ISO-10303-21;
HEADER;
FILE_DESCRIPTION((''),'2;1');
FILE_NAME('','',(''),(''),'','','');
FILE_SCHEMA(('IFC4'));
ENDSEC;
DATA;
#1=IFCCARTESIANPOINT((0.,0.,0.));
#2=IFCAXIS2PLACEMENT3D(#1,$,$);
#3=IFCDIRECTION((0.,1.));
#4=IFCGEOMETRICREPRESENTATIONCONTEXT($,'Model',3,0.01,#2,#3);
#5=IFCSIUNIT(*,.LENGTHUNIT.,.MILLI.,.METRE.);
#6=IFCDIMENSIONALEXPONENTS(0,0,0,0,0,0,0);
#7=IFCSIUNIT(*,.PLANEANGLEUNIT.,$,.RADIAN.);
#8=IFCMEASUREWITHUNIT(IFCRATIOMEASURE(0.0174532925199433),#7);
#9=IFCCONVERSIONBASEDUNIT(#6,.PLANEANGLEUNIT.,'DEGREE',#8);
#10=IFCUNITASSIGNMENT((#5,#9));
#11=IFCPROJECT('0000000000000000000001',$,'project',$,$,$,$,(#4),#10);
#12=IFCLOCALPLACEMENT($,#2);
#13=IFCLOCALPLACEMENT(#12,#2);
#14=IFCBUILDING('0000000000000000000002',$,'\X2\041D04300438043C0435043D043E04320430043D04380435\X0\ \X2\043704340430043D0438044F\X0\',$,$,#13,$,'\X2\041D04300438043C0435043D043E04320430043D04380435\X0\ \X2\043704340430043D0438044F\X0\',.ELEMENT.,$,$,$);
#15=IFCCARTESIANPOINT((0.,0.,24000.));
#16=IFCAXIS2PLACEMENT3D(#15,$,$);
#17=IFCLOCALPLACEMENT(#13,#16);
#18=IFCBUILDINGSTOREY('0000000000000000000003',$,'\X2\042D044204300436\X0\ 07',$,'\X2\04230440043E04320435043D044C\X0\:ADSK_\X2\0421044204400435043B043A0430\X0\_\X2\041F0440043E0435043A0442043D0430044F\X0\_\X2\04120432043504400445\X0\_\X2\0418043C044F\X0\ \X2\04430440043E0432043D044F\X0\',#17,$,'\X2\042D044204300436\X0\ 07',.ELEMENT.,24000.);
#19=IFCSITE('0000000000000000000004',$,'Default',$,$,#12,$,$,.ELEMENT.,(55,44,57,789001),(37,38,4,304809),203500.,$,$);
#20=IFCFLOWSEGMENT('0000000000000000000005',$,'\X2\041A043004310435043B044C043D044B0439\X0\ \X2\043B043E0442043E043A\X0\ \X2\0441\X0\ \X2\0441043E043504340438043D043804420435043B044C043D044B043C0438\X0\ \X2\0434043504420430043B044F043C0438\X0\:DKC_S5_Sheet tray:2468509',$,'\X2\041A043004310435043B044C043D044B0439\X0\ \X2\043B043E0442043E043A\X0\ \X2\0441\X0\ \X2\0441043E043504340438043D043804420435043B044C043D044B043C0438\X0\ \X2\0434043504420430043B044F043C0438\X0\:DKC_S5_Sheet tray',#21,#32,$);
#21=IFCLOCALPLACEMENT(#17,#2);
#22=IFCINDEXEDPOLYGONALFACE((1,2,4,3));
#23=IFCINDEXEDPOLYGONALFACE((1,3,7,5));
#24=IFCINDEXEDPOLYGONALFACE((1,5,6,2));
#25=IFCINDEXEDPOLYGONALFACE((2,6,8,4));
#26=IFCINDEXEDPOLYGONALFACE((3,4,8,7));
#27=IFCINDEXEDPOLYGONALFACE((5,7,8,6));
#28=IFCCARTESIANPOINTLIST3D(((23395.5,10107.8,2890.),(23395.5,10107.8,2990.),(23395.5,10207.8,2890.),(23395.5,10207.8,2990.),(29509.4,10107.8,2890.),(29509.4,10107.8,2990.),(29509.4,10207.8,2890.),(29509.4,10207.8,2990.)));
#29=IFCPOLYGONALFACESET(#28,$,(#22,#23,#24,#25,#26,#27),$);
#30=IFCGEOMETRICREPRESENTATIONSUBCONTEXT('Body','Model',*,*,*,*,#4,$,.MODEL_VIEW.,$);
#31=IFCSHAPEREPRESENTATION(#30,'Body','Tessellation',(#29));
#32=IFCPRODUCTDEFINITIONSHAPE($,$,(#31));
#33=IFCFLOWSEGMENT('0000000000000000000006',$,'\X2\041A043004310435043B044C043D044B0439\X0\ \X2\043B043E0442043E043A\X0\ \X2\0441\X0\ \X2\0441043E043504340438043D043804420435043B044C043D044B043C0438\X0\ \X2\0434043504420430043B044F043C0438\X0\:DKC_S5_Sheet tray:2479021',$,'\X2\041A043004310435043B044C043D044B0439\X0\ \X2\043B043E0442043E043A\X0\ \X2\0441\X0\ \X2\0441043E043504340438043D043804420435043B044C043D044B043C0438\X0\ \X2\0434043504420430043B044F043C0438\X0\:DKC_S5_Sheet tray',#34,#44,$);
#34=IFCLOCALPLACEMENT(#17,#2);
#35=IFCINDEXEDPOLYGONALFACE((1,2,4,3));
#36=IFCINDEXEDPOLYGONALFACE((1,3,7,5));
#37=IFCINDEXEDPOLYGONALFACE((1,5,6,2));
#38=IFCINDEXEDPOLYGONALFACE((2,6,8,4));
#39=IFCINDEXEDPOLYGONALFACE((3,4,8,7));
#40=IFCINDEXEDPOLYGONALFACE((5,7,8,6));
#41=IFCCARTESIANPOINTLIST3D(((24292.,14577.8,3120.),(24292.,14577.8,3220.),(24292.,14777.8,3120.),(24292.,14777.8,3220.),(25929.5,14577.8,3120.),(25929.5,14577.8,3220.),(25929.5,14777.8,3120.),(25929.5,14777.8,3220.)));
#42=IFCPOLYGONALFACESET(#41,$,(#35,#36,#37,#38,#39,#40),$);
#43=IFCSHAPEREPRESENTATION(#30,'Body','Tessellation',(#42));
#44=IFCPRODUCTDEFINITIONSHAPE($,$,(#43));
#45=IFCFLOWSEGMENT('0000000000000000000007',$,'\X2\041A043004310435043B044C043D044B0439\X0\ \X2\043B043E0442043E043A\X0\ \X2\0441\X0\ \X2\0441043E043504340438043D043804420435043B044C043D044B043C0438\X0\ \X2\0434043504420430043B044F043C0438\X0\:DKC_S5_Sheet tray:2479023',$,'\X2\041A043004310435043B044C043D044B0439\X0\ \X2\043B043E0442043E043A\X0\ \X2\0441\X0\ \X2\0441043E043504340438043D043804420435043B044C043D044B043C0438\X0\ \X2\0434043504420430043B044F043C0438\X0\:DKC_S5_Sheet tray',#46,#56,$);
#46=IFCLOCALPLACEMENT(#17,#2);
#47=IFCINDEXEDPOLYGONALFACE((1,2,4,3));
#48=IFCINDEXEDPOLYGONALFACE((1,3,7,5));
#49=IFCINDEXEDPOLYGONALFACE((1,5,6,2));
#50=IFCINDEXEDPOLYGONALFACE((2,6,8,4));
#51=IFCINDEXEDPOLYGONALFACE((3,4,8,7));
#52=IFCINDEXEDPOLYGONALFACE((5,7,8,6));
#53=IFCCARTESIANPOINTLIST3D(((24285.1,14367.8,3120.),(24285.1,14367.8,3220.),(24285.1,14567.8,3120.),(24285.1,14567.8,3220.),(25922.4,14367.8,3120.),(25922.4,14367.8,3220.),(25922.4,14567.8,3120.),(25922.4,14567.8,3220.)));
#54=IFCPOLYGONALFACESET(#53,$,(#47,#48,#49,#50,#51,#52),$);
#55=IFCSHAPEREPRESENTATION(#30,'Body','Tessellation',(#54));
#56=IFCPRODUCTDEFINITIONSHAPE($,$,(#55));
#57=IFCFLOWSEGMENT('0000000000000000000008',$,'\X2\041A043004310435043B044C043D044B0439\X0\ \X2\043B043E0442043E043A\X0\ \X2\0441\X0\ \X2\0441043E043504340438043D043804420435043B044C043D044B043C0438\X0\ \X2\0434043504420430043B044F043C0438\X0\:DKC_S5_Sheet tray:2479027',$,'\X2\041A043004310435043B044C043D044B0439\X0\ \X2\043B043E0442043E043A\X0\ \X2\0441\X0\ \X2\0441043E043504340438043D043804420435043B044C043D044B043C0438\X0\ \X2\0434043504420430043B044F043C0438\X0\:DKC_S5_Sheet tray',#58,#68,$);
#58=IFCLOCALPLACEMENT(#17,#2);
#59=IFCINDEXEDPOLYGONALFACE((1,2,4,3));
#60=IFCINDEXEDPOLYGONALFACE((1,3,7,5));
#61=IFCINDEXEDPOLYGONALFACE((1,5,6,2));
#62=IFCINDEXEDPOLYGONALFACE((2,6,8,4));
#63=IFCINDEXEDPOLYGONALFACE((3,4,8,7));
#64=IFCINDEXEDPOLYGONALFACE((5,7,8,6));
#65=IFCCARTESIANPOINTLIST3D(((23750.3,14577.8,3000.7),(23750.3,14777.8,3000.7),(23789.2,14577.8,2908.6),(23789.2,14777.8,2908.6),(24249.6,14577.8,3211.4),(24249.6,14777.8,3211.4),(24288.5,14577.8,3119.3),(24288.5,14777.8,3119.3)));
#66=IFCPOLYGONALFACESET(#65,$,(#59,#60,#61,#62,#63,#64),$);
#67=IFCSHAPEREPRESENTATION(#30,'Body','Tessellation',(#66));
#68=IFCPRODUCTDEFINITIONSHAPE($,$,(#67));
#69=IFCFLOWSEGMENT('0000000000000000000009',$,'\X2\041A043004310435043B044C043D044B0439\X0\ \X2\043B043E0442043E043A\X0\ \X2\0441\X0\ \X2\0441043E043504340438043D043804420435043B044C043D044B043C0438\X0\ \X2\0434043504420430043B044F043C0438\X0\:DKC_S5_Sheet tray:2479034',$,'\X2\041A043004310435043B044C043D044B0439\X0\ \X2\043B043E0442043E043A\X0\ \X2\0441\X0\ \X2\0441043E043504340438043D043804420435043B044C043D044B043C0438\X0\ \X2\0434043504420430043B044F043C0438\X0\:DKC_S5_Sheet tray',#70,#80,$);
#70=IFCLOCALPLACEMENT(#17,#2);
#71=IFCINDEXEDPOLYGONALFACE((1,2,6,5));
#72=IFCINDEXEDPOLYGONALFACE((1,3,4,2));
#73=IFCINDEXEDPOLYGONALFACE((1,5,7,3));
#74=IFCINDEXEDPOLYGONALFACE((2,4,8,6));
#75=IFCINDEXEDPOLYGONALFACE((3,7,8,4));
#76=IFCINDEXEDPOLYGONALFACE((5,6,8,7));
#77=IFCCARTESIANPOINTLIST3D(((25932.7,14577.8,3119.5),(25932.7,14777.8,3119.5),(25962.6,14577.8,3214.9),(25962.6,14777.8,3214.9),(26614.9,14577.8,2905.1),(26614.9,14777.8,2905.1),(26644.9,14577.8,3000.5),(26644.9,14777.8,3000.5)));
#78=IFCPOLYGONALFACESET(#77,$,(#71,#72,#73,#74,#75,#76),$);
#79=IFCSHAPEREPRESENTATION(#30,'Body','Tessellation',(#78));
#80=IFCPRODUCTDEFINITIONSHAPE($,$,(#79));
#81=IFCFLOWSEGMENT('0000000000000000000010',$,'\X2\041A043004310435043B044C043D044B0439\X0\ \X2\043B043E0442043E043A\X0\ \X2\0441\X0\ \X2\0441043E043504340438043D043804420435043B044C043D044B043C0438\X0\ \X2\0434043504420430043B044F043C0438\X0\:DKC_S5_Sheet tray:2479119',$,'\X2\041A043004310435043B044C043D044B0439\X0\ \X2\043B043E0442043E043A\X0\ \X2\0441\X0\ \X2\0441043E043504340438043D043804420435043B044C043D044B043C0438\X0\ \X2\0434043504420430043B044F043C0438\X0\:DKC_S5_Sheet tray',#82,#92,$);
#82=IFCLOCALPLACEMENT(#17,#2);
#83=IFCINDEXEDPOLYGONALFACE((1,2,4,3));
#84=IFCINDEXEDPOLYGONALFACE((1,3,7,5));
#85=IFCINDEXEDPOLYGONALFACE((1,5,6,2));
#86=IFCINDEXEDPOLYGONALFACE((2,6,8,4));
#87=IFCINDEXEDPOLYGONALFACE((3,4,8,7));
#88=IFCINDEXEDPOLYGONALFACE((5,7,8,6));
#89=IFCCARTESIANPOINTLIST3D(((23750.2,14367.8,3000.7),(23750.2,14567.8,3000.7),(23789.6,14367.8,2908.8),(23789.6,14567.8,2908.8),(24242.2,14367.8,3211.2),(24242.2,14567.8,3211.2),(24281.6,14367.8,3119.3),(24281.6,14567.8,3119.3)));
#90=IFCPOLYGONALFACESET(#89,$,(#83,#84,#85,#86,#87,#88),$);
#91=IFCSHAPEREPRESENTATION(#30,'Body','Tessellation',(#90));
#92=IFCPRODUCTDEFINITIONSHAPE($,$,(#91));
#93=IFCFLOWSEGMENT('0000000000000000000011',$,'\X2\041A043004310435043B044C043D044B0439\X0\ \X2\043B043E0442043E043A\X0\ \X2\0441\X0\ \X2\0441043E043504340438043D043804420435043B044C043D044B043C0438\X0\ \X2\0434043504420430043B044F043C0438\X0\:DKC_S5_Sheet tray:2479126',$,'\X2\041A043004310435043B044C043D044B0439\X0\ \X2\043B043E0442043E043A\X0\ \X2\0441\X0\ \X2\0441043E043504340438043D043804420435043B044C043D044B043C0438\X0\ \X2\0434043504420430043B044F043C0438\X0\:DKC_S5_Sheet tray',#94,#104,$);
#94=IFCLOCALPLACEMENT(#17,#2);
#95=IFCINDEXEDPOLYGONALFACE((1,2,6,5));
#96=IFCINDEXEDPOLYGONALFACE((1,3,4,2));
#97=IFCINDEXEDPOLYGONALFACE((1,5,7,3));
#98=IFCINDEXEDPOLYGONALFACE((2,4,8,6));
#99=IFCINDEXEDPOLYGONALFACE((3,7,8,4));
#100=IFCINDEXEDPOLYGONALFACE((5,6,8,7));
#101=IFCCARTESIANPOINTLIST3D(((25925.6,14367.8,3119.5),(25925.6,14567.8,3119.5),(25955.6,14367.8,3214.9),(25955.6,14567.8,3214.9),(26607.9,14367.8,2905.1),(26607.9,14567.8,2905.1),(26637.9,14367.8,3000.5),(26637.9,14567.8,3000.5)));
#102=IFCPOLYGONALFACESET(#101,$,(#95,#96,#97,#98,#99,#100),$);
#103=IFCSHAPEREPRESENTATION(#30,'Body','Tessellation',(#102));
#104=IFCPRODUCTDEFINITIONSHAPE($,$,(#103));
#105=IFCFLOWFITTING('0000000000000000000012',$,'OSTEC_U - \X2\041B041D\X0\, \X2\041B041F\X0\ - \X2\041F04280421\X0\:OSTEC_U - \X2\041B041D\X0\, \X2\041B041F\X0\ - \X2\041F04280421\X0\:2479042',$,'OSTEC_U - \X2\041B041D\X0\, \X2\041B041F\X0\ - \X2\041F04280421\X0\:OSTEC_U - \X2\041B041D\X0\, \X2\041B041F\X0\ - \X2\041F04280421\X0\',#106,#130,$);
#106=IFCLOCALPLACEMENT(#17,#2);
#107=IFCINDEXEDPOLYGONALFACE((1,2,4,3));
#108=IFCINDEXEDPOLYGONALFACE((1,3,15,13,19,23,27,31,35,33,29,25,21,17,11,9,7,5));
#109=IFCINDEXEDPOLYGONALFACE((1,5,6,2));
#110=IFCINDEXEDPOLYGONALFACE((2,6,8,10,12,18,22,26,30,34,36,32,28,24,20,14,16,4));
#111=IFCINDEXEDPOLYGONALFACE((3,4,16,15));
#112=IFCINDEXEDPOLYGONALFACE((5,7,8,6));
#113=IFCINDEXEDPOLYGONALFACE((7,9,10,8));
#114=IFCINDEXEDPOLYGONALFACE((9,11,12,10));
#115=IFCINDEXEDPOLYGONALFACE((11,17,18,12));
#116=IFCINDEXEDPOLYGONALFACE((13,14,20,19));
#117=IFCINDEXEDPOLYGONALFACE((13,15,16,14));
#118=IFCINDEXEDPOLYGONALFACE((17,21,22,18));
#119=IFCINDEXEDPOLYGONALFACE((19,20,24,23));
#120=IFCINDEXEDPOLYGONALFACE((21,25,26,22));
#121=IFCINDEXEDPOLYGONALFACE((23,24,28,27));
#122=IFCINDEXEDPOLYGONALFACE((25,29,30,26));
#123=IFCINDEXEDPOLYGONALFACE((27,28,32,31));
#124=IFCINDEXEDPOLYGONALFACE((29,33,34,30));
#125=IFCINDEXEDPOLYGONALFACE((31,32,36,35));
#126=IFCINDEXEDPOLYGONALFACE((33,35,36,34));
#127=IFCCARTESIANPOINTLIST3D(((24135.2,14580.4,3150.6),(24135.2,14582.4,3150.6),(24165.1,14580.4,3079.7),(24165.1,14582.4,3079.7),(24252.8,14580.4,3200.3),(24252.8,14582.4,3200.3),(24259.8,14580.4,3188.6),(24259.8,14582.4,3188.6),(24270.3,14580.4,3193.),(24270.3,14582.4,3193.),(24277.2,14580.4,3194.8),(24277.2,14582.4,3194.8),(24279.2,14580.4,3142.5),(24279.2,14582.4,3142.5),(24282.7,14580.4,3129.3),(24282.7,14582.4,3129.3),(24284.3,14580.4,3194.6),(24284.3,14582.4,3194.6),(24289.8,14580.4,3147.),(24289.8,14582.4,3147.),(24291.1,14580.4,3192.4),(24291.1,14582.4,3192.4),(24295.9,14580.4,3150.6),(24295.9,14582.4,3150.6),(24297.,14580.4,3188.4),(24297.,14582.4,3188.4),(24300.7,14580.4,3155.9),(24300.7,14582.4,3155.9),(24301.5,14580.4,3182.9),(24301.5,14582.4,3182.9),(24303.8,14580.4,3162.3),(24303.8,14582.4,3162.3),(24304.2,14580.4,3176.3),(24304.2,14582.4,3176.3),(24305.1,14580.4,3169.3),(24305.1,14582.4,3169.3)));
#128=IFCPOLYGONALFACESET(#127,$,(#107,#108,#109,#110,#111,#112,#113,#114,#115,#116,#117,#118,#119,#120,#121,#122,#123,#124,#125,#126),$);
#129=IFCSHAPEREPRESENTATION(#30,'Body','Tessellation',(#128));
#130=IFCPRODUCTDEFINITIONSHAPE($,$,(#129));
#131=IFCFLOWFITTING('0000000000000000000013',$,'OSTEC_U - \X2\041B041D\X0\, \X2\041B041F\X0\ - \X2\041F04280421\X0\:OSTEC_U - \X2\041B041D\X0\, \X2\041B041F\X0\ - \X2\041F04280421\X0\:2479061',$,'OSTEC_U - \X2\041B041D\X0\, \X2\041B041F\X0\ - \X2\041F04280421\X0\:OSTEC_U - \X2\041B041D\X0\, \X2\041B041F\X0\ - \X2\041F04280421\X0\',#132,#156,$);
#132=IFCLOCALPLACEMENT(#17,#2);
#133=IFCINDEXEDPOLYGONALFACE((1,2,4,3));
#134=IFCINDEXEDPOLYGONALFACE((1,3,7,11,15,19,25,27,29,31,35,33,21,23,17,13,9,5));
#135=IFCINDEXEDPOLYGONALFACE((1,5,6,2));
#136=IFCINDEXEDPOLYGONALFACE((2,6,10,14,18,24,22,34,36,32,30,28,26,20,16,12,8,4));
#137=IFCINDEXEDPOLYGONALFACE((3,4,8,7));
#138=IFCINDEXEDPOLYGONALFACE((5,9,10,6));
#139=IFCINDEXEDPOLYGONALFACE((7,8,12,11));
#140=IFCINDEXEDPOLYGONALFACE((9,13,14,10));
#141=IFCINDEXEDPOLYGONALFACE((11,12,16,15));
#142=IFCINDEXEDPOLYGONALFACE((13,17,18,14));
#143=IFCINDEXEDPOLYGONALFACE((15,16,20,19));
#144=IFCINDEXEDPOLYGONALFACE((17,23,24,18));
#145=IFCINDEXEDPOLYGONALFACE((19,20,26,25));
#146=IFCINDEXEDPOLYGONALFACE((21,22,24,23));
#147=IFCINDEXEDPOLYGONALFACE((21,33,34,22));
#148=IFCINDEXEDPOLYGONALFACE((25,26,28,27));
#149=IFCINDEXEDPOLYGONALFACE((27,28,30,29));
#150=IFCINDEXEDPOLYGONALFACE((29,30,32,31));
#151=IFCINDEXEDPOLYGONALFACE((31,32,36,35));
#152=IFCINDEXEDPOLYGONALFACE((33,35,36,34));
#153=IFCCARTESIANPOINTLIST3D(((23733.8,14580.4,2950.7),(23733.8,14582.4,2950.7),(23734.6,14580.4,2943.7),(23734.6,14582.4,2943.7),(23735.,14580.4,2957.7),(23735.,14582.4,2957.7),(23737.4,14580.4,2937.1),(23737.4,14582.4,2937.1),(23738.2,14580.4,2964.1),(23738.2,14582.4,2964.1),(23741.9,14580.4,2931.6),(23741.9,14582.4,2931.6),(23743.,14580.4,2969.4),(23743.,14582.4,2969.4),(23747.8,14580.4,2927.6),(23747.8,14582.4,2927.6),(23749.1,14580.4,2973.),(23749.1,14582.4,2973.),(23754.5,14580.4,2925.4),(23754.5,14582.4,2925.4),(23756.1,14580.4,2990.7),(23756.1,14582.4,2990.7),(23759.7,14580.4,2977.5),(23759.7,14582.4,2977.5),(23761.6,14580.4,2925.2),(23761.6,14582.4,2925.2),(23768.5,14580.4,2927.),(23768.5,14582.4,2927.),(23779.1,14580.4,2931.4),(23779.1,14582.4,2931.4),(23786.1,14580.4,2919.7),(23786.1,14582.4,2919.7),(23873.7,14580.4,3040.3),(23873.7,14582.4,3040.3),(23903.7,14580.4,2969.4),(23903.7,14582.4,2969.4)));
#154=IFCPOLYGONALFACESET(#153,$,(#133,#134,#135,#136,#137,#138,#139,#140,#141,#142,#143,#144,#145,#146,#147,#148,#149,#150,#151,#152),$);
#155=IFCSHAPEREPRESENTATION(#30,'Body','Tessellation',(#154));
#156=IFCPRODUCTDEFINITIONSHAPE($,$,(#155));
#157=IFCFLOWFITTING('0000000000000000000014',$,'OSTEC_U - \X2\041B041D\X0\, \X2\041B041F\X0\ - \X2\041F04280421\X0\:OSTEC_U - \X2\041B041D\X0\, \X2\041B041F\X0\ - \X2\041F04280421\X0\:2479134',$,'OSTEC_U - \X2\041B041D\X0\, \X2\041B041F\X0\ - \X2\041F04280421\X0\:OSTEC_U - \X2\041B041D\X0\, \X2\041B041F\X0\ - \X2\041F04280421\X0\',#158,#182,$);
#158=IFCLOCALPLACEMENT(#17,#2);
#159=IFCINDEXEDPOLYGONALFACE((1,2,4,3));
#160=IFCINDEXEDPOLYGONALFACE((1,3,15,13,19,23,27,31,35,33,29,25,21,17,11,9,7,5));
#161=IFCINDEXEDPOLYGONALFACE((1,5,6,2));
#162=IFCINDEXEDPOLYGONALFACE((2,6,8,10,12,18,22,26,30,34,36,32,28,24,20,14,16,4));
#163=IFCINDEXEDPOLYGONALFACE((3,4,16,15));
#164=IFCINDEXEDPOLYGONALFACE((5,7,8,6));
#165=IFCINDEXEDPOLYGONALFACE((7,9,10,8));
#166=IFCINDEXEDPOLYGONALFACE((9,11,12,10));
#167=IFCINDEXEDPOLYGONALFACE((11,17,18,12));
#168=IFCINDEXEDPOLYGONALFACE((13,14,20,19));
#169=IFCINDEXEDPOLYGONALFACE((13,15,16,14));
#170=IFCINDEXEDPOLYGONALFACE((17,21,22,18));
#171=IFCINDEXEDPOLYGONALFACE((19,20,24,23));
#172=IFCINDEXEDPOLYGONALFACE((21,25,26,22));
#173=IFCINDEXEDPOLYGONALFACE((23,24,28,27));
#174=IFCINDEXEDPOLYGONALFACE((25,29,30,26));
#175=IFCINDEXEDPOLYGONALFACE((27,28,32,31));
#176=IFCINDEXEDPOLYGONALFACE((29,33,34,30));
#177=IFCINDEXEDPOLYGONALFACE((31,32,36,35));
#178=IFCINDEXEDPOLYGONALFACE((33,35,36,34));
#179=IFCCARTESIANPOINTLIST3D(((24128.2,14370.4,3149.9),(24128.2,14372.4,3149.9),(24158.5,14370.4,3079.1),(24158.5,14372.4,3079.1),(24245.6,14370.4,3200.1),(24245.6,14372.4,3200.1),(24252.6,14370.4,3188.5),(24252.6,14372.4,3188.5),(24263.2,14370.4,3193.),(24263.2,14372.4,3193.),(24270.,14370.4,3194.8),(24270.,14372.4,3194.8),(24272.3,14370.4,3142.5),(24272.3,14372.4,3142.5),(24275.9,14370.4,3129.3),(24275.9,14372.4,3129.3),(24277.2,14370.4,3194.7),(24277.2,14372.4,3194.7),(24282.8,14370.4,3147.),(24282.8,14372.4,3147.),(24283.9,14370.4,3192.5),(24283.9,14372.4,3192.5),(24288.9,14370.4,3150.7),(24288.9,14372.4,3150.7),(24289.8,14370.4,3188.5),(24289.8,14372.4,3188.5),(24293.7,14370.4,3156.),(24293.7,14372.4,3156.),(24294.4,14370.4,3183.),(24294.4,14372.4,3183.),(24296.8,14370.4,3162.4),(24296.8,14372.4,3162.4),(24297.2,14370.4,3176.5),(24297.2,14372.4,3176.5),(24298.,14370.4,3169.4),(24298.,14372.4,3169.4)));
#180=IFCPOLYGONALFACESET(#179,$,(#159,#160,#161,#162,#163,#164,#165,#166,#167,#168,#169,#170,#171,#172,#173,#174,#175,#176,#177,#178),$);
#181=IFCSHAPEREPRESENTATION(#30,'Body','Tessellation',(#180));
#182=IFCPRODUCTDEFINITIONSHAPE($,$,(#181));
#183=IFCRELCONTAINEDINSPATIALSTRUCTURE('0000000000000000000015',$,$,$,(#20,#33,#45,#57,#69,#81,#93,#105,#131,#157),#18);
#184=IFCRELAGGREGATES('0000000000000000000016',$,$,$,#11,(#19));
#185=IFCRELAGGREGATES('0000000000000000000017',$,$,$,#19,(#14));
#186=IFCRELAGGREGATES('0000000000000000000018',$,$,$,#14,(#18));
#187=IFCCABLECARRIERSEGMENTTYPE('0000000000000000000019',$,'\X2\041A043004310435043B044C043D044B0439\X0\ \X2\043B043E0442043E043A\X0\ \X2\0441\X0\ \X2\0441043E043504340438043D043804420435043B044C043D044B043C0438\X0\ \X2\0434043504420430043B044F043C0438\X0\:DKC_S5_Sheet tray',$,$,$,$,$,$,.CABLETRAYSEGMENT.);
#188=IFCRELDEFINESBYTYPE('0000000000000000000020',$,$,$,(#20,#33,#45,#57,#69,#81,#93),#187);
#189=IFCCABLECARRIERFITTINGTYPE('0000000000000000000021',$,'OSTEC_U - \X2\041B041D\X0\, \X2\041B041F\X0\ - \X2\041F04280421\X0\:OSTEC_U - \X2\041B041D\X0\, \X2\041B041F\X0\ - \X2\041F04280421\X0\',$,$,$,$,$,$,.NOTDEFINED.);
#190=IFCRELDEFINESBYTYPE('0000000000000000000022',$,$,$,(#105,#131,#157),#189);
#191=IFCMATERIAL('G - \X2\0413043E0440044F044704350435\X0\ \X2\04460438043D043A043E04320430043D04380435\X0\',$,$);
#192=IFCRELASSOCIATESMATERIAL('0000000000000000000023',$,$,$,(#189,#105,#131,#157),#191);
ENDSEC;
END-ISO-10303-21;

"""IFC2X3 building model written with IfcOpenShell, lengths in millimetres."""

from ifc_helpers import new_model, entity, si_unit, converted_unit, direction, frame, frame_2d, origin, origin_2d_with_axis, place, context, subcontext, project, spatial, polyline, circle_curve, parameter, trimmed, segment, composite_curve, rectangle, outline, extrude, source, transform, mapped, material, type_object, type_shapes, element, save


model = new_model("IFC2X3")

# Units and contexts
model_context = context("Model", 3, precision=0.01, world=origin(), true_north=direction((0.0, 1.0)))
body_context = subcontext(model_context, "Body", "Model", "MODEL_VIEW")
ifc_project = project(units=[si_unit("LENGTHUNIT", "METRE", prefix="MILLI"), converted_unit("PLANEANGLEUNIT", "DEGREE", entity("IfcRatioMeasure", 0.0174532925199433), si_unit("PLANEANGLEUNIT", "RADIAN"), dimensions=[0, 0, 0, 0, 0, 0, 0])], contexts=[model_context])

# Site, building, storey
site_placement = place(None, frame((0.0, 0.0, 0.0)))
site = spatial("IfcSite", under=ifc_project, at=site_placement, Name="Default", CompositionType="ELEMENT", RefLatitude=(55, 44, 57, 789001), RefLongitude=(37, 38, 4, 304809), RefElevation=203500.0)
building_placement = place(site_placement, origin())
building = spatial("IfcBuilding", under=site, at=building_placement, Name="Наименование здания", LongName="Наименование здания", CompositionType="ELEMENT")
storey_placement = place(building_placement, frame((0.0, 0.0, 24000.0)))
storey = spatial("IfcBuildingStorey", under=building, at=storey_placement, Name="Этаж 07", ObjectType="Уровень:ADSK_Стрелка_Проектная_Вверх_Имя уровня", LongName="Этаж 07", CompositionType="ELEMENT", Elevation=24000.0)

# Flow segments
cable_carrier_segment_type = type_object("IfcCableCarrierSegmentType", Name="Кабельный лоток с соединительными деталями:DKC_S5_Sheet tray", PredefinedType="CABLETRAYSEGMENT")
flow_segment_1_placement = place(storey_placement, frame((23395.5, 10107.8, 2890.0)))
element("IfcFlowSegment", 1, at=flow_segment_1_placement, inside=storey, type_object=cable_carrier_segment_type, Name="Кабельный лоток с соединительными деталями:DKC_S5_Sheet tray:2468509", ObjectType="Кабельный лоток с соединительными деталями:DKC_S5_Sheet tray", context=body_context, shape_type="SweptSolid", body=[
    extrude(rectangle(XDim=6114.0, YDim=100.0, at=frame_2d((0.0, 0.0), x_axis=(1.0, 0.0))), frame((3057.0, 50.0, 0.0), z_axis=(0.0, 0.0, 1.0), x_axis=(-1.0, 0.0, 0.0)), (0.0, 0.0, 1.0), 100.0),
])
flow_segment_2_placement = place(storey_placement, frame((24292.0, 14577.8, 3120.0)))
element("IfcFlowSegment", 2, at=flow_segment_2_placement, inside=storey, type_object=cable_carrier_segment_type, Name="Кабельный лоток с соединительными деталями:DKC_S5_Sheet tray:2479021", ObjectType="Кабельный лоток с соединительными деталями:DKC_S5_Sheet tray", context=body_context, shape_type="SweptSolid", body=[
    extrude(rectangle(XDim=1637.5, YDim=200.0, at=frame_2d((0.0, 0.0), x_axis=(1.0, 0.0))), frame((818.8, 100.0, 0.0), z_axis=(0.0, 0.0, 1.0), x_axis=(-1.0, 0.0, 0.0)), (0.0, 0.0, 1.0), 100.0),
])
flow_segment_3_placement = place(storey_placement, frame((24285.1, 14367.8, 3120.0)))
element("IfcFlowSegment", 3, at=flow_segment_3_placement, inside=storey, type_object=cable_carrier_segment_type, Name="Кабельный лоток с соединительными деталями:DKC_S5_Sheet tray:2479023", ObjectType="Кабельный лоток с соединительными деталями:DKC_S5_Sheet tray", context=body_context, shape_type="SweptSolid", body=[
    extrude(rectangle(XDim=1637.4, YDim=200.0, at=origin_2d_with_axis()), frame((818.7, 100.0, 0.0)), (0.0, 0.0, 1.0), 100.0),
])
flow_segment_4_placement = place(storey_placement, frame((23750.3, 14577.8, 2908.6)))
element("IfcFlowSegment", 4, at=flow_segment_4_placement, inside=storey, type_object=cable_carrier_segment_type, Name="Кабельный лоток с соединительными деталями:DKC_S5_Sheet tray:2479027", ObjectType="Кабельный лоток с соединительными деталями:DKC_S5_Sheet tray", context=body_context, shape_type="SweptSolid", body=[
    extrude(rectangle(XDim=100.0, YDim=200.0, at=frame_2d((0.0, 0.0), x_axis=(1.0, 0.0))), frame((19.4, 100.0, 46.1), z_axis=(0.921308, 0.0, 0.388834), x_axis=(-0.388834, 0.0, 0.921308)), (0.0, 0.0, 1.0), 541.9),
])
flow_segment_5_placement = place(storey_placement, frame((25932.7, 14577.8, 2905.1)))
element("IfcFlowSegment", 5, at=flow_segment_5_placement, inside=storey, type_object=cable_carrier_segment_type, Name="Кабельный лоток с соединительными деталями:DKC_S5_Sheet tray:2479034", ObjectType="Кабельный лоток с соединительными деталями:DKC_S5_Sheet tray", context=body_context, shape_type="SweptSolid", body=[
    extrude(rectangle(XDim=100.0, YDim=200.0, at=frame_2d((0.0, 0.0), x_axis=(1.0, 0.0))), frame((15.0, 100.0, 262.1), z_axis=(0.953994, 0.0, -0.299827), x_axis=(0.299827, 0.0, 0.953994)), (0.0, 0.0, 1.0), 715.2),
])
flow_segment_6_placement = place(storey_placement, frame((23750.2, 14367.8, 2908.8)))
element("IfcFlowSegment", 6, at=flow_segment_6_placement, inside=storey, type_object=cable_carrier_segment_type, Name="Кабельный лоток с соединительными деталями:DKC_S5_Sheet tray:2479119", ObjectType="Кабельный лоток с соединительными деталями:DKC_S5_Sheet tray", context=body_context, shape_type="SweptSolid", body=[
    extrude(rectangle(XDim=100.0, YDim=200.0, at=frame_2d((0.0, 0.0), x_axis=(1.0, 0.0))), frame((19.7, 100.0, 46.0), z_axis=(0.919387, 0.0, 0.393354), x_axis=(-0.393354, 0.0, 0.919387)), (0.0, 0.0, 1.0), 535.2),
])
flow_segment_7_placement = place(storey_placement, frame((25925.6, 14367.8, 2905.1)))
element("IfcFlowSegment", 7, at=flow_segment_7_placement, inside=storey, type_object=cable_carrier_segment_type, Name="Кабельный лоток с соединительными деталями:DKC_S5_Sheet tray:2479126", ObjectType="Кабельный лоток с соединительными деталями:DKC_S5_Sheet tray", context=body_context, shape_type="SweptSolid", body=[
    extrude(rectangle(XDim=100.0, YDim=200.0, at=frame_2d((0.0, 0.0), x_axis=(1.0, 0.0))), frame((15.0, 100.0, 262.1), z_axis=(0.953994, 0.0, -0.299827), x_axis=(0.299827, 0.0, 0.953994)), (0.0, 0.0, 1.0), 715.2),
])

# Flow fittings
ifc_material_1 = material(Name="G - Горячее цинкование")
cable_carrier_fitting_type_1 = type_object("IfcCableCarrierFittingType", Name="OSTEC_U - ЛН, ЛП - ПШС:OSTEC_U - ЛН, ЛП - ПШС", PredefinedType="NOTDEFINED", material=ifc_material_1)
shared_shape_1 = source(origin(), body_context, "Body", "SweptSolid", [
    extrude(outline(composite_curve([segment(trimmed(circle_curve(frame_2d((-41.5, 0.0), x_axis=(1.0, 0.0)), 25.0), [parameter(90.0)], [parameter(270.0)], True, "PARAMETER"), True, "CONTINUOUS"), segment(polyline([(-41.5, -25.0), (-30.0, -25.0)]), True, "CONTINUOUS"), segment(polyline([(-30.0, -25.0), (-28.1, -38.5)]), True, "CONTINUOUS"), segment(polyline([(-28.1, -38.5), (99.5, -38.5)]), True, "CONTINUOUS"), segment(polyline([(99.5, -38.5), (99.5, 38.5)]), True, "CONTINUOUS"), segment(polyline([(99.5, 38.5), (-28.1, 38.5)]), True, "CONTINUOUS"), segment(polyline([(-28.1, 38.5), (-30.0, 25.0)]), True, "CONTINUOUS"), segment(polyline([(-30.0, 25.0), (-41.5, 25.0)]), True, "CONTINUOUS")], self_intersect=False)), frame((41.5, 0.0, 0.0), z_axis=(0.0, 0.0, -1.0), x_axis=(1.0, 0.0, 0.0)), (0.0, 0.0, -1.0), 2.0),
])
type_shapes(cable_carrier_fitting_type_1, [shared_shape_1])
for number, where, z_axis, x_axis, name in (
    (8, (24280.1, 14582.4, 3170.0), (0.0, -1.0, 0.0), (-0.921308, 0.0, -0.388834), "OSTEC_U - ЛН, ЛП - ПШС:OSTEC_U - ЛН, ЛП - ПШС:2479042"),
    (9, (23758.8, 14582.4, 2950.0), (0.0, -1.0, 0.0), (0.921308, 0.0, 0.388834), "OSTEC_U - ЛН, ЛП - ПШС:OSTEC_U - ЛН, ЛП - ПШС:2479061"),
    (10, (24273.0, 14372.4, 3170.0), (0.0, -1.0, 0.0), (-0.919387, 0.0, -0.393354), "OSTEC_U - ЛН, ЛП - ПШС:OSTEC_U - ЛН, ЛП - ПШС:2479134"),
):
    element("IfcFlowFitting", number, at=place(storey_placement, frame(where, z_axis=z_axis, x_axis=x_axis)), inside=storey, type_object=cable_carrier_fitting_type_1, material=ifc_material_1, Name=name, ObjectType="OSTEC_U - ЛН, ЛП - ПШС:OSTEC_U - ЛН, ЛП - ПШС", context=body_context, shape_type="MappedRepresentation", body=[
        mapped(shared_shape_1, transform((0.0, 0.0, 0.0), scale=1.0)),
    ])

save(model, "model.ifc")
